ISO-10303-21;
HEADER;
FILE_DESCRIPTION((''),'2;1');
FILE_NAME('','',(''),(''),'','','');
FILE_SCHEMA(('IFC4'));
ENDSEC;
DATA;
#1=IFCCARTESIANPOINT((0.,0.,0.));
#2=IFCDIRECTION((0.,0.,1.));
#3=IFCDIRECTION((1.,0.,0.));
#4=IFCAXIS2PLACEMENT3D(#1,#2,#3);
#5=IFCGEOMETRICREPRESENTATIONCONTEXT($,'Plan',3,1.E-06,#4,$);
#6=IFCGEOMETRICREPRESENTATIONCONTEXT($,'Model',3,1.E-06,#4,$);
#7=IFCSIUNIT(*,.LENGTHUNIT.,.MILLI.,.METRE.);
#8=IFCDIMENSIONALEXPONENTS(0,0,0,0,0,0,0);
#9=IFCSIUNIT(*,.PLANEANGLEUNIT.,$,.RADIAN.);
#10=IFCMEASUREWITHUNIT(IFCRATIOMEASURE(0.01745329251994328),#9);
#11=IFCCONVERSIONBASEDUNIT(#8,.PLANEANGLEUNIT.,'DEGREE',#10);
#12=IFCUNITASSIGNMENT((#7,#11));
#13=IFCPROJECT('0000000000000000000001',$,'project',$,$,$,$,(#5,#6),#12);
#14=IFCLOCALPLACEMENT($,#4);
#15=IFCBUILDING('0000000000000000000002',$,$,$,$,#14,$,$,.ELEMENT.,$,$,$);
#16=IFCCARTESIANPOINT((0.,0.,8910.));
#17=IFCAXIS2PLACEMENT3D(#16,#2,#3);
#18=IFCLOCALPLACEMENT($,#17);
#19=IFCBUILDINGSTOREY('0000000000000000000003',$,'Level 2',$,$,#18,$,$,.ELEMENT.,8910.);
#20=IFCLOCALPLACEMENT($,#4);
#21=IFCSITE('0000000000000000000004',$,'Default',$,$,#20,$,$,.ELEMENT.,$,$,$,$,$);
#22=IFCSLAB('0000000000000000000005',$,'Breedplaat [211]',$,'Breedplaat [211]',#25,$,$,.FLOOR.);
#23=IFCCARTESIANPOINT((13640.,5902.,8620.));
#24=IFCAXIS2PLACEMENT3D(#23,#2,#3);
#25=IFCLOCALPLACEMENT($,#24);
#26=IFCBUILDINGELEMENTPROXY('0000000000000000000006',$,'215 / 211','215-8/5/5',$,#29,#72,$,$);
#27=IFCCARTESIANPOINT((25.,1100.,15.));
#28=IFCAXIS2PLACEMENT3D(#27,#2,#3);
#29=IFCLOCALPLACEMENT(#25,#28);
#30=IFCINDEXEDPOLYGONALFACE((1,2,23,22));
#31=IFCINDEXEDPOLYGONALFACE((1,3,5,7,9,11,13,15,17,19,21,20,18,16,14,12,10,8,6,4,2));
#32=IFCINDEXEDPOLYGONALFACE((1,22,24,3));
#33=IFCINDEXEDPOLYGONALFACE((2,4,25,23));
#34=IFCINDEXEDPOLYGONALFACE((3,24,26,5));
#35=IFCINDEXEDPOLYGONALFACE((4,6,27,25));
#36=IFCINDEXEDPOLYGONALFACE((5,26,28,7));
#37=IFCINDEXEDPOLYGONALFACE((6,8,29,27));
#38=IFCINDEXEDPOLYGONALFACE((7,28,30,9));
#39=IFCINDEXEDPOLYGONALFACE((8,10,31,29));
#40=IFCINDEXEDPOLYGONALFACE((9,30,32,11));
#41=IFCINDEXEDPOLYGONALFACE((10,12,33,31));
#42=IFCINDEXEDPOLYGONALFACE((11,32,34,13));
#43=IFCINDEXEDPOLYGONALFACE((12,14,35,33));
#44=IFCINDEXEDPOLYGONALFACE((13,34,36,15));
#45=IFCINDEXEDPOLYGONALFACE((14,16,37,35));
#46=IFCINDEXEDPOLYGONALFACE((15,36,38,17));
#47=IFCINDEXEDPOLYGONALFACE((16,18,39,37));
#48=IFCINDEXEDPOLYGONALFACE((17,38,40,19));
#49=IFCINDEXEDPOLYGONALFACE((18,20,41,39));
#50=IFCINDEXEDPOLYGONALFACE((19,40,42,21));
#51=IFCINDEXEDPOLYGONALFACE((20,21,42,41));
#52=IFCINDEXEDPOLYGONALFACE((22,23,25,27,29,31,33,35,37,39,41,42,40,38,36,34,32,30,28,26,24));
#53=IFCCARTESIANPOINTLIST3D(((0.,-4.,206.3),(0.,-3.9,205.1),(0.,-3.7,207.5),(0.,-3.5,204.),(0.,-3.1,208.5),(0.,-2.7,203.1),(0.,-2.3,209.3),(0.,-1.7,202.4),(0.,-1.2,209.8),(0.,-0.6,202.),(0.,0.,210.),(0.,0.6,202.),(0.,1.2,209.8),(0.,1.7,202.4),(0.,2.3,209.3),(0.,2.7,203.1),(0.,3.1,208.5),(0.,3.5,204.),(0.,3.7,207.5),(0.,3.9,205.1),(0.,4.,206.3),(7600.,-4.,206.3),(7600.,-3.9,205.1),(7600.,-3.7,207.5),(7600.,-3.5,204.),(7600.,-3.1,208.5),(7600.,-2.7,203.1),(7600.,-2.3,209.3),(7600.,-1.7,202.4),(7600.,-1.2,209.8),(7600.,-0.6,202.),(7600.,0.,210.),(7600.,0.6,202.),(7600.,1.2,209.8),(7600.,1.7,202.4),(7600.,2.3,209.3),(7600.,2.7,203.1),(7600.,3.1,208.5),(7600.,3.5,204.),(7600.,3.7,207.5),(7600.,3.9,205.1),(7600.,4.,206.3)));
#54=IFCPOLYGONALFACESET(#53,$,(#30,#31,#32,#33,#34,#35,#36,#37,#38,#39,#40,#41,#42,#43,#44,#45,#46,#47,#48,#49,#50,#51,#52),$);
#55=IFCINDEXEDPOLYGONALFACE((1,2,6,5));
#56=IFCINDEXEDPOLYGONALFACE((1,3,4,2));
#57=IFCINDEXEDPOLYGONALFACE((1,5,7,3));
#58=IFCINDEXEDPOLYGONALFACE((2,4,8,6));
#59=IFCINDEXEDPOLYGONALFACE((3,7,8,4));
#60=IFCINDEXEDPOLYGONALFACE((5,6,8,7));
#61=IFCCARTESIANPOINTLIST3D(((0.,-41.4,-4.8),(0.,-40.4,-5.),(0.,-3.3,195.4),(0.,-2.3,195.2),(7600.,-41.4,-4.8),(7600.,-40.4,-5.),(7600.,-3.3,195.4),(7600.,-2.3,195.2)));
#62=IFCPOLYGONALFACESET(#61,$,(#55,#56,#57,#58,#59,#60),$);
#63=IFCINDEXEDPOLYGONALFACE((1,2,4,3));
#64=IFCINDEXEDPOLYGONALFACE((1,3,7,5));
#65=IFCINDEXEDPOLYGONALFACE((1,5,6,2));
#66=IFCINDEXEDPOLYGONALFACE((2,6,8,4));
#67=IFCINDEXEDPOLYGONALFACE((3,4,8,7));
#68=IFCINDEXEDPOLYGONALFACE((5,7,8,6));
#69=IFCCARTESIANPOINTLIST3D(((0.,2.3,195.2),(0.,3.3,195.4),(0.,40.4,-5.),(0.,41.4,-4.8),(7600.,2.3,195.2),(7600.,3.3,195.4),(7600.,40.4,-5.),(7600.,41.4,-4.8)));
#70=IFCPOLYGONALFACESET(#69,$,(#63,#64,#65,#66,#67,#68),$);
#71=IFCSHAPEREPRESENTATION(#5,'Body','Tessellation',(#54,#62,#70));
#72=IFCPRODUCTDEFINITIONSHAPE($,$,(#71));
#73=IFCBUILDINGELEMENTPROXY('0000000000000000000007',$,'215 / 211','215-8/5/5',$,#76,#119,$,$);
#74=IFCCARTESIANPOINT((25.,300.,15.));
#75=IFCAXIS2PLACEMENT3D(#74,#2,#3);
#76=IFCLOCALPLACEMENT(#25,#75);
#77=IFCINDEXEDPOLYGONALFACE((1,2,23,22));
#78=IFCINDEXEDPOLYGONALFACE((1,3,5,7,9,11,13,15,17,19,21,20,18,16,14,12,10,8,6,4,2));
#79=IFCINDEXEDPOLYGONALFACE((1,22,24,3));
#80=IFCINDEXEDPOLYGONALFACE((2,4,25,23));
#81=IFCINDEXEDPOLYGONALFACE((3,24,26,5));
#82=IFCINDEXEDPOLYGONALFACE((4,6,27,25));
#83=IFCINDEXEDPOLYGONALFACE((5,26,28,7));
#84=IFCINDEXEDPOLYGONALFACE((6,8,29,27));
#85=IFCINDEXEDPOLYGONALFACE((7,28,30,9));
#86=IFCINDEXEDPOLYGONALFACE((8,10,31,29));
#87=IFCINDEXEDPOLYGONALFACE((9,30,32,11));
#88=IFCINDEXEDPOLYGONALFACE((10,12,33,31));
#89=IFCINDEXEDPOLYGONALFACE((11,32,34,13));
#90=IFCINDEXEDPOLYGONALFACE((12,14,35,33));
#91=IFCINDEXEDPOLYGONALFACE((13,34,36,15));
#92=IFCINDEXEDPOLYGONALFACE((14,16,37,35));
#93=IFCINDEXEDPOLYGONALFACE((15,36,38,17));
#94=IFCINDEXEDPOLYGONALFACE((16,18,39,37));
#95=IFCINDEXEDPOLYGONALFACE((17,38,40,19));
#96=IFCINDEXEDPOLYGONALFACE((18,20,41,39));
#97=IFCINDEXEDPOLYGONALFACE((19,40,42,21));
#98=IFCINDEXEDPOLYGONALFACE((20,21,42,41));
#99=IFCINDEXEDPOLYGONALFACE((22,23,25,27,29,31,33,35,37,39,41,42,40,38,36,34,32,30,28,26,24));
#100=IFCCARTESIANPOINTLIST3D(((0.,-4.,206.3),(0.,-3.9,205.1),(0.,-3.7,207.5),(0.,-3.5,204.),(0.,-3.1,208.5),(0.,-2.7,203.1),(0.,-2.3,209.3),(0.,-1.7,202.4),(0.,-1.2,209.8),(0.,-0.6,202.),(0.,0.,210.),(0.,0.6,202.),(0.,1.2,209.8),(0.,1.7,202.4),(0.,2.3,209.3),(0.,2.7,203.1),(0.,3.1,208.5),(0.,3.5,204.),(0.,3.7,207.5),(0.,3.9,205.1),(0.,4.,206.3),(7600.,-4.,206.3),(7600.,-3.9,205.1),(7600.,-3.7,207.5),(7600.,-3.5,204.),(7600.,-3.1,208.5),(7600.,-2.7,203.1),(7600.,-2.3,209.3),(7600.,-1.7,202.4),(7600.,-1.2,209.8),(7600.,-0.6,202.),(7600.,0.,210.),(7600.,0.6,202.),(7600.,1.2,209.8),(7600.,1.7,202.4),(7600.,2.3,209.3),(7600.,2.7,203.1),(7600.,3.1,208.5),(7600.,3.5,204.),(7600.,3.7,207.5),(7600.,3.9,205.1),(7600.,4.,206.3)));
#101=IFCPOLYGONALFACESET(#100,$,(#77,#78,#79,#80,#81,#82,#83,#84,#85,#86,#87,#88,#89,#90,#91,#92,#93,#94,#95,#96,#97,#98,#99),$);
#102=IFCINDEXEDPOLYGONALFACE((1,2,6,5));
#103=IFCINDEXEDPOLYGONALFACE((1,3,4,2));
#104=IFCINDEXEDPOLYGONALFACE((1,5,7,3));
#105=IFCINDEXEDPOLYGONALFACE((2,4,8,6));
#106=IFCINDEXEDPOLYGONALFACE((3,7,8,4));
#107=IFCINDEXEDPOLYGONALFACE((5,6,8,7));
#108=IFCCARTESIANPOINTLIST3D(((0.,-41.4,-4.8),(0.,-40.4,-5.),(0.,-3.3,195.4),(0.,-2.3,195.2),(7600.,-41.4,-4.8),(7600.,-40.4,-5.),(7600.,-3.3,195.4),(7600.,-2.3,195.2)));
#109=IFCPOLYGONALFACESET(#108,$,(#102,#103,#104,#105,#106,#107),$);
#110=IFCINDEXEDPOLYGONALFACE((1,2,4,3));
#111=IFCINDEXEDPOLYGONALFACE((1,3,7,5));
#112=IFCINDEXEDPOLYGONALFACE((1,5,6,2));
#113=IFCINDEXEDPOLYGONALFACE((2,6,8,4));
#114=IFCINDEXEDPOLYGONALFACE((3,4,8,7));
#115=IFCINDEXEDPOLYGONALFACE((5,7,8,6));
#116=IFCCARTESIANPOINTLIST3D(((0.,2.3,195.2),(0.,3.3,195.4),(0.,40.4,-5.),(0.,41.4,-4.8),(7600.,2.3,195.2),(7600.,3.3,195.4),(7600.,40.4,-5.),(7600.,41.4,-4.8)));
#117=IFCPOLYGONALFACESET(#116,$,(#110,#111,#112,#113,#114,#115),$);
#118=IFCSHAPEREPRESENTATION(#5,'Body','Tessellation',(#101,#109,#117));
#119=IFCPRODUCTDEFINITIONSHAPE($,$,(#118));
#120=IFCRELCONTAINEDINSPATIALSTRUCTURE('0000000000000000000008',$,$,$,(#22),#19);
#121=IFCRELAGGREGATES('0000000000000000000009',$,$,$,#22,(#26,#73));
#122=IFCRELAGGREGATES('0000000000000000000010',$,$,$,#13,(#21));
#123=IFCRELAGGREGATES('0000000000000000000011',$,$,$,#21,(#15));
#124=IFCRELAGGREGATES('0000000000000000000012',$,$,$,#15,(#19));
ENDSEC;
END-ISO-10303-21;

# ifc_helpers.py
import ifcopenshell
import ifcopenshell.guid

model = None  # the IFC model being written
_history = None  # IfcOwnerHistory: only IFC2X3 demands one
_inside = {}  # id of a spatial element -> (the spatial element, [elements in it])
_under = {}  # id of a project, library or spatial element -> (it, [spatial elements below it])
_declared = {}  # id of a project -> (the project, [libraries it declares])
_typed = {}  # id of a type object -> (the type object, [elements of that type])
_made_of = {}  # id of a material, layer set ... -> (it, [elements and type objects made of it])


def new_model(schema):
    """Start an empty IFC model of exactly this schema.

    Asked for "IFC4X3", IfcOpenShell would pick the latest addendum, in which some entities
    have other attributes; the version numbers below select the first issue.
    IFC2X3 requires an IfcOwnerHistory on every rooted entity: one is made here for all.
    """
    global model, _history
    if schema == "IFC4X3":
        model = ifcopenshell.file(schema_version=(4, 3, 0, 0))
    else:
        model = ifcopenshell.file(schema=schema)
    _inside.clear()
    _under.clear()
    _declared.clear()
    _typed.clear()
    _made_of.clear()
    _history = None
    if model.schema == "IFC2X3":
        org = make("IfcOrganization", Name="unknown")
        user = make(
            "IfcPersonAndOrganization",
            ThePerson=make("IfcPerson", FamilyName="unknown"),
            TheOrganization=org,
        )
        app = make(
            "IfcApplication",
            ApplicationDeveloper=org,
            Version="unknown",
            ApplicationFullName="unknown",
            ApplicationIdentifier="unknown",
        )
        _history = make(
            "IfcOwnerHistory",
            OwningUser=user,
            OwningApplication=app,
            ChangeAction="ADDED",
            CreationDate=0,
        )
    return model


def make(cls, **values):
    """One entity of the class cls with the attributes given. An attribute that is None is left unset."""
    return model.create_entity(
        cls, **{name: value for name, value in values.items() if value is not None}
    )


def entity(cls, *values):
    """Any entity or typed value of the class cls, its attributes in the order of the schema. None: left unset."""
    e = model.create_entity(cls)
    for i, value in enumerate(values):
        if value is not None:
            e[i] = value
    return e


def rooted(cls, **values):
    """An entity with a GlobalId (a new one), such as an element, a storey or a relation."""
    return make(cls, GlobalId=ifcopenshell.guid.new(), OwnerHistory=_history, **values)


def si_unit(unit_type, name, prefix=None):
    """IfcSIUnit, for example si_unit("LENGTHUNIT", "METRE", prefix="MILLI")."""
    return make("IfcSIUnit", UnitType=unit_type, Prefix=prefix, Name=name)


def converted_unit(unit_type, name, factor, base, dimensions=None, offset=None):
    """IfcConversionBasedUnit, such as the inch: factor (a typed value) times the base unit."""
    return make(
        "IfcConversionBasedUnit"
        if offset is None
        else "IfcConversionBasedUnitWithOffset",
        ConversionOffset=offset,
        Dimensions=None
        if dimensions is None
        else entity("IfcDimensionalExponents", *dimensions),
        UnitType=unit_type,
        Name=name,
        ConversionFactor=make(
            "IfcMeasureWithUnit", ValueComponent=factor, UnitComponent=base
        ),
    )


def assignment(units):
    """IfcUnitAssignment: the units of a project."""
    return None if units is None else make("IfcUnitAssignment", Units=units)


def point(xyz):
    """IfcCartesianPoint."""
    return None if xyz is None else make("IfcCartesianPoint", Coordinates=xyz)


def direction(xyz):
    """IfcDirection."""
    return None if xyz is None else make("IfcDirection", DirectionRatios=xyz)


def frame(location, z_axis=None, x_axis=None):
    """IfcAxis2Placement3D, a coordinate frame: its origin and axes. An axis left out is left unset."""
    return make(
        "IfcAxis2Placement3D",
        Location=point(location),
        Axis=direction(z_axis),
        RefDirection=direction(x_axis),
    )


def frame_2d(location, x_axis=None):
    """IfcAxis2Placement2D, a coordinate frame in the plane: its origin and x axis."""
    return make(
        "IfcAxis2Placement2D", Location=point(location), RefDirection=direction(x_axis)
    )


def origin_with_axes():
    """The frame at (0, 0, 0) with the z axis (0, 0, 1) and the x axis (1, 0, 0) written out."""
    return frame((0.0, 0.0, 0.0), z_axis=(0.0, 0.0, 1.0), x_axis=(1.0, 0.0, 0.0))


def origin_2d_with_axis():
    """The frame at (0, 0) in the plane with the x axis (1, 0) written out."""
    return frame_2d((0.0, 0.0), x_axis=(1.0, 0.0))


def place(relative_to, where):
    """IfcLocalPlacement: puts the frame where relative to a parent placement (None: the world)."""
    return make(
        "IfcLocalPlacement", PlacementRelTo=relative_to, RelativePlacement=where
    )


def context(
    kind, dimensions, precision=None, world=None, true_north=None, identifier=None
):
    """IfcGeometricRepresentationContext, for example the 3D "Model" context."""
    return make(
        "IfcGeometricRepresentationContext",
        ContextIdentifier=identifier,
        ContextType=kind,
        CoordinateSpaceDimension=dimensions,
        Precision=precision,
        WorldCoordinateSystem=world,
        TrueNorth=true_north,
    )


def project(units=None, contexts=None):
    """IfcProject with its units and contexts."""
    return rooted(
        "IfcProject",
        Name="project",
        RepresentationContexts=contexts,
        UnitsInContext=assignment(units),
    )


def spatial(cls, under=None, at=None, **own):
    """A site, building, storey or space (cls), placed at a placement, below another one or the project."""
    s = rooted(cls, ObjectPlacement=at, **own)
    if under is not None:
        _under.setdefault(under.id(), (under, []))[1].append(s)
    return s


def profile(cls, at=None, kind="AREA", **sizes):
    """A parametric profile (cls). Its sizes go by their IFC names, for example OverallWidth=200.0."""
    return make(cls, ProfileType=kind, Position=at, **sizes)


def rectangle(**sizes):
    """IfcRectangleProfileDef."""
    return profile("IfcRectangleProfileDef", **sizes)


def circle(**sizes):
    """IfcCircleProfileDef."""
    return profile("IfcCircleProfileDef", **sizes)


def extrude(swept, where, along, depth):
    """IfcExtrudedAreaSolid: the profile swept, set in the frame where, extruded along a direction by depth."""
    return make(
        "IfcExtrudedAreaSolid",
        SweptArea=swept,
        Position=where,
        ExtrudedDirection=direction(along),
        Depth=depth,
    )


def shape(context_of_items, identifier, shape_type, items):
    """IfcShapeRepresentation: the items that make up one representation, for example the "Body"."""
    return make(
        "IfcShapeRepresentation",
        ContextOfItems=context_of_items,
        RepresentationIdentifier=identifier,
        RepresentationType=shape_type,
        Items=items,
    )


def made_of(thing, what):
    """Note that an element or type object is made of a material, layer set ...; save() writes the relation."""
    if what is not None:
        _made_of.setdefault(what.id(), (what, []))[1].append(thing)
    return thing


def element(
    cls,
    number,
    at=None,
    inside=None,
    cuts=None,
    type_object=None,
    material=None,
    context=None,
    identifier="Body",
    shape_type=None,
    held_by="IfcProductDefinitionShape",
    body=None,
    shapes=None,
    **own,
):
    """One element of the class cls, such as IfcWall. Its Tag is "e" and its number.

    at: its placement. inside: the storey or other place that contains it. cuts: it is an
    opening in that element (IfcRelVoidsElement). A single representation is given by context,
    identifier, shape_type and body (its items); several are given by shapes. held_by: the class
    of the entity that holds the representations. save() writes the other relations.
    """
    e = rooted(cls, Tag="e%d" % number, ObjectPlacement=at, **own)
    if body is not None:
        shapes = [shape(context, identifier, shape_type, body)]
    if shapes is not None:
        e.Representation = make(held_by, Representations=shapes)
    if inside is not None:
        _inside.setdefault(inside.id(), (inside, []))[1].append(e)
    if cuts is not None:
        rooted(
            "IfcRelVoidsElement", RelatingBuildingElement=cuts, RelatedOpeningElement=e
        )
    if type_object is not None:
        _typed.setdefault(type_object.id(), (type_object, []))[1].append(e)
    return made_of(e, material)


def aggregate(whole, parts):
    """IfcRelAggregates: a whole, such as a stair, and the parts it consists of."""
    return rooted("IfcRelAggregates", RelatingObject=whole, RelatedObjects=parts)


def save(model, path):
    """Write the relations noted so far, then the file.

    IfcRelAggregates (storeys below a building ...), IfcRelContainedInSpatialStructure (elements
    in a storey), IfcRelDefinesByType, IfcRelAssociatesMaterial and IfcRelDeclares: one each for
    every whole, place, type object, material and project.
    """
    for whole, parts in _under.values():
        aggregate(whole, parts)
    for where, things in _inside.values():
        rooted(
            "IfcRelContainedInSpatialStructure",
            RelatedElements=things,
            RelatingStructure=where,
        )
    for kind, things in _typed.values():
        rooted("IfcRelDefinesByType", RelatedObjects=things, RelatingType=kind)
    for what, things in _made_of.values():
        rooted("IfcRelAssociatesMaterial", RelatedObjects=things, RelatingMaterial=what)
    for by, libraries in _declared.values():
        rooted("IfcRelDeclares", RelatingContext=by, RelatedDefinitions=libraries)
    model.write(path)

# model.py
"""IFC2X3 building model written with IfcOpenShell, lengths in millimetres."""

from ifc_helpers import new_model, entity, si_unit, converted_unit, frame, origin_with_axes, origin_2d_with_axis, place, context, project, spatial, rectangle, circle, extrude, element, aggregate, save


model = new_model("IFC2X3")

# Units and contexts
plan_context = context("Plan", 3, precision=1e-06, world=origin_with_axes())
model_context = context("Model", 3, precision=1e-06, world=origin_with_axes())
ifc_project = project(units=[si_unit("LENGTHUNIT", "METRE", prefix="MILLI"), converted_unit("PLANEANGLEUNIT", "DEGREE", entity("IfcRatioMeasure", 0.01745329251994328), si_unit("PLANEANGLEUNIT", "RADIAN"), dimensions=[0, 0, 0, 0, 0, 0, 0])], contexts=[plan_context, model_context])

# Site, building, storey
site_placement = place(None, origin_with_axes())
site = spatial("IfcSite", under=ifc_project, at=site_placement, Name="Default", CompositionType="ELEMENT")
building_placement = place(None, origin_with_axes())
building = spatial("IfcBuilding", under=site, at=building_placement, CompositionType="ELEMENT")
storey_placement = place(None, frame((0.0, 0.0, 8910.0), z_axis=(0.0, 0.0, 1.0), x_axis=(1.0, 0.0, 0.0)))
storey = spatial("IfcBuildingStorey", under=building, at=storey_placement, Name="Level 2", CompositionType="ELEMENT", Elevation=8910.0)

# Slab, building element proxies
slab_1_placement = place(None, frame((13640.0, 5902.0, 8620.0), z_axis=(0.0, 0.0, 1.0), x_axis=(1.0, 0.0, 0.0)))
slab_1 = element("IfcSlab", 1, at=slab_1_placement, inside=storey, Name="Breedplaat [211]", ObjectType="Breedplaat [211]", PredefinedType="FLOOR")
proxy_1_placement = place(slab_1_placement, frame((25.0, 1100.0, 15.0), z_axis=(0.0, 0.0, 1.0), x_axis=(1.0, 0.0, 0.0)))
proxy_1 = element("IfcBuildingElementProxy", 2, at=proxy_1_placement, Name="215 / 211", Description="215-8/5/5", context=plan_context, shape_type="SweptSolid", body=[
    extrude(circle(Radius=4.0, at=origin_2d_with_axis()), frame((0.0, 0.0, 206.0), z_axis=(1.0, 0.0, 0.0), x_axis=(0.0, 0.0, 1.0)), (0.0, 0.0, 1.0), 7600.0),
    extrude(rectangle(XDim=203.8, YDim=1.0, at=origin_2d_with_axis()), frame((0.0, -21.9, 95.2), z_axis=(1.0, 0.0, 0.0), x_axis=(0.0, 0.187112, 0.982339)), (0.0, 0.0, 1.0), 7600.0),
    extrude(rectangle(XDim=203.8, YDim=1.0, at=origin_2d_with_axis()), frame((0.0, 21.9, 95.2), z_axis=(1.0, 0.0, 0.0), x_axis=(0.0, -0.187112, 0.982339)), (0.0, 0.0, 1.0), 7600.0),
])
proxy_2_placement = place(slab_1_placement, frame((25.0, 300.0, 15.0), z_axis=(0.0, 0.0, 1.0), x_axis=(1.0, 0.0, 0.0)))
proxy_2 = element("IfcBuildingElementProxy", 3, at=proxy_2_placement, Name="215 / 211", Description="215-8/5/5", context=plan_context, shape_type="SweptSolid", body=[
    extrude(circle(Radius=4.0, at=origin_2d_with_axis()), frame((0.0, 0.0, 206.0), z_axis=(1.0, 0.0, 0.0), x_axis=(0.0, 0.0, 1.0)), (0.0, 0.0, 1.0), 7600.0),
    extrude(rectangle(XDim=203.8, YDim=1.0, at=origin_2d_with_axis()), frame((0.0, -21.9, 95.2), z_axis=(1.0, 0.0, 0.0), x_axis=(0.0, 0.187112, 0.982339)), (0.0, 0.0, 1.0), 7600.0),
    extrude(rectangle(XDim=203.8, YDim=1.0, at=origin_2d_with_axis()), frame((0.0, 21.9, 95.2), z_axis=(1.0, 0.0, 0.0), x_axis=(0.0, -0.187112, 0.982339)), (0.0, 0.0, 1.0), 7600.0),
])
aggregate(slab_1, [proxy_1, proxy_2])

save(model, "model.ifc")
